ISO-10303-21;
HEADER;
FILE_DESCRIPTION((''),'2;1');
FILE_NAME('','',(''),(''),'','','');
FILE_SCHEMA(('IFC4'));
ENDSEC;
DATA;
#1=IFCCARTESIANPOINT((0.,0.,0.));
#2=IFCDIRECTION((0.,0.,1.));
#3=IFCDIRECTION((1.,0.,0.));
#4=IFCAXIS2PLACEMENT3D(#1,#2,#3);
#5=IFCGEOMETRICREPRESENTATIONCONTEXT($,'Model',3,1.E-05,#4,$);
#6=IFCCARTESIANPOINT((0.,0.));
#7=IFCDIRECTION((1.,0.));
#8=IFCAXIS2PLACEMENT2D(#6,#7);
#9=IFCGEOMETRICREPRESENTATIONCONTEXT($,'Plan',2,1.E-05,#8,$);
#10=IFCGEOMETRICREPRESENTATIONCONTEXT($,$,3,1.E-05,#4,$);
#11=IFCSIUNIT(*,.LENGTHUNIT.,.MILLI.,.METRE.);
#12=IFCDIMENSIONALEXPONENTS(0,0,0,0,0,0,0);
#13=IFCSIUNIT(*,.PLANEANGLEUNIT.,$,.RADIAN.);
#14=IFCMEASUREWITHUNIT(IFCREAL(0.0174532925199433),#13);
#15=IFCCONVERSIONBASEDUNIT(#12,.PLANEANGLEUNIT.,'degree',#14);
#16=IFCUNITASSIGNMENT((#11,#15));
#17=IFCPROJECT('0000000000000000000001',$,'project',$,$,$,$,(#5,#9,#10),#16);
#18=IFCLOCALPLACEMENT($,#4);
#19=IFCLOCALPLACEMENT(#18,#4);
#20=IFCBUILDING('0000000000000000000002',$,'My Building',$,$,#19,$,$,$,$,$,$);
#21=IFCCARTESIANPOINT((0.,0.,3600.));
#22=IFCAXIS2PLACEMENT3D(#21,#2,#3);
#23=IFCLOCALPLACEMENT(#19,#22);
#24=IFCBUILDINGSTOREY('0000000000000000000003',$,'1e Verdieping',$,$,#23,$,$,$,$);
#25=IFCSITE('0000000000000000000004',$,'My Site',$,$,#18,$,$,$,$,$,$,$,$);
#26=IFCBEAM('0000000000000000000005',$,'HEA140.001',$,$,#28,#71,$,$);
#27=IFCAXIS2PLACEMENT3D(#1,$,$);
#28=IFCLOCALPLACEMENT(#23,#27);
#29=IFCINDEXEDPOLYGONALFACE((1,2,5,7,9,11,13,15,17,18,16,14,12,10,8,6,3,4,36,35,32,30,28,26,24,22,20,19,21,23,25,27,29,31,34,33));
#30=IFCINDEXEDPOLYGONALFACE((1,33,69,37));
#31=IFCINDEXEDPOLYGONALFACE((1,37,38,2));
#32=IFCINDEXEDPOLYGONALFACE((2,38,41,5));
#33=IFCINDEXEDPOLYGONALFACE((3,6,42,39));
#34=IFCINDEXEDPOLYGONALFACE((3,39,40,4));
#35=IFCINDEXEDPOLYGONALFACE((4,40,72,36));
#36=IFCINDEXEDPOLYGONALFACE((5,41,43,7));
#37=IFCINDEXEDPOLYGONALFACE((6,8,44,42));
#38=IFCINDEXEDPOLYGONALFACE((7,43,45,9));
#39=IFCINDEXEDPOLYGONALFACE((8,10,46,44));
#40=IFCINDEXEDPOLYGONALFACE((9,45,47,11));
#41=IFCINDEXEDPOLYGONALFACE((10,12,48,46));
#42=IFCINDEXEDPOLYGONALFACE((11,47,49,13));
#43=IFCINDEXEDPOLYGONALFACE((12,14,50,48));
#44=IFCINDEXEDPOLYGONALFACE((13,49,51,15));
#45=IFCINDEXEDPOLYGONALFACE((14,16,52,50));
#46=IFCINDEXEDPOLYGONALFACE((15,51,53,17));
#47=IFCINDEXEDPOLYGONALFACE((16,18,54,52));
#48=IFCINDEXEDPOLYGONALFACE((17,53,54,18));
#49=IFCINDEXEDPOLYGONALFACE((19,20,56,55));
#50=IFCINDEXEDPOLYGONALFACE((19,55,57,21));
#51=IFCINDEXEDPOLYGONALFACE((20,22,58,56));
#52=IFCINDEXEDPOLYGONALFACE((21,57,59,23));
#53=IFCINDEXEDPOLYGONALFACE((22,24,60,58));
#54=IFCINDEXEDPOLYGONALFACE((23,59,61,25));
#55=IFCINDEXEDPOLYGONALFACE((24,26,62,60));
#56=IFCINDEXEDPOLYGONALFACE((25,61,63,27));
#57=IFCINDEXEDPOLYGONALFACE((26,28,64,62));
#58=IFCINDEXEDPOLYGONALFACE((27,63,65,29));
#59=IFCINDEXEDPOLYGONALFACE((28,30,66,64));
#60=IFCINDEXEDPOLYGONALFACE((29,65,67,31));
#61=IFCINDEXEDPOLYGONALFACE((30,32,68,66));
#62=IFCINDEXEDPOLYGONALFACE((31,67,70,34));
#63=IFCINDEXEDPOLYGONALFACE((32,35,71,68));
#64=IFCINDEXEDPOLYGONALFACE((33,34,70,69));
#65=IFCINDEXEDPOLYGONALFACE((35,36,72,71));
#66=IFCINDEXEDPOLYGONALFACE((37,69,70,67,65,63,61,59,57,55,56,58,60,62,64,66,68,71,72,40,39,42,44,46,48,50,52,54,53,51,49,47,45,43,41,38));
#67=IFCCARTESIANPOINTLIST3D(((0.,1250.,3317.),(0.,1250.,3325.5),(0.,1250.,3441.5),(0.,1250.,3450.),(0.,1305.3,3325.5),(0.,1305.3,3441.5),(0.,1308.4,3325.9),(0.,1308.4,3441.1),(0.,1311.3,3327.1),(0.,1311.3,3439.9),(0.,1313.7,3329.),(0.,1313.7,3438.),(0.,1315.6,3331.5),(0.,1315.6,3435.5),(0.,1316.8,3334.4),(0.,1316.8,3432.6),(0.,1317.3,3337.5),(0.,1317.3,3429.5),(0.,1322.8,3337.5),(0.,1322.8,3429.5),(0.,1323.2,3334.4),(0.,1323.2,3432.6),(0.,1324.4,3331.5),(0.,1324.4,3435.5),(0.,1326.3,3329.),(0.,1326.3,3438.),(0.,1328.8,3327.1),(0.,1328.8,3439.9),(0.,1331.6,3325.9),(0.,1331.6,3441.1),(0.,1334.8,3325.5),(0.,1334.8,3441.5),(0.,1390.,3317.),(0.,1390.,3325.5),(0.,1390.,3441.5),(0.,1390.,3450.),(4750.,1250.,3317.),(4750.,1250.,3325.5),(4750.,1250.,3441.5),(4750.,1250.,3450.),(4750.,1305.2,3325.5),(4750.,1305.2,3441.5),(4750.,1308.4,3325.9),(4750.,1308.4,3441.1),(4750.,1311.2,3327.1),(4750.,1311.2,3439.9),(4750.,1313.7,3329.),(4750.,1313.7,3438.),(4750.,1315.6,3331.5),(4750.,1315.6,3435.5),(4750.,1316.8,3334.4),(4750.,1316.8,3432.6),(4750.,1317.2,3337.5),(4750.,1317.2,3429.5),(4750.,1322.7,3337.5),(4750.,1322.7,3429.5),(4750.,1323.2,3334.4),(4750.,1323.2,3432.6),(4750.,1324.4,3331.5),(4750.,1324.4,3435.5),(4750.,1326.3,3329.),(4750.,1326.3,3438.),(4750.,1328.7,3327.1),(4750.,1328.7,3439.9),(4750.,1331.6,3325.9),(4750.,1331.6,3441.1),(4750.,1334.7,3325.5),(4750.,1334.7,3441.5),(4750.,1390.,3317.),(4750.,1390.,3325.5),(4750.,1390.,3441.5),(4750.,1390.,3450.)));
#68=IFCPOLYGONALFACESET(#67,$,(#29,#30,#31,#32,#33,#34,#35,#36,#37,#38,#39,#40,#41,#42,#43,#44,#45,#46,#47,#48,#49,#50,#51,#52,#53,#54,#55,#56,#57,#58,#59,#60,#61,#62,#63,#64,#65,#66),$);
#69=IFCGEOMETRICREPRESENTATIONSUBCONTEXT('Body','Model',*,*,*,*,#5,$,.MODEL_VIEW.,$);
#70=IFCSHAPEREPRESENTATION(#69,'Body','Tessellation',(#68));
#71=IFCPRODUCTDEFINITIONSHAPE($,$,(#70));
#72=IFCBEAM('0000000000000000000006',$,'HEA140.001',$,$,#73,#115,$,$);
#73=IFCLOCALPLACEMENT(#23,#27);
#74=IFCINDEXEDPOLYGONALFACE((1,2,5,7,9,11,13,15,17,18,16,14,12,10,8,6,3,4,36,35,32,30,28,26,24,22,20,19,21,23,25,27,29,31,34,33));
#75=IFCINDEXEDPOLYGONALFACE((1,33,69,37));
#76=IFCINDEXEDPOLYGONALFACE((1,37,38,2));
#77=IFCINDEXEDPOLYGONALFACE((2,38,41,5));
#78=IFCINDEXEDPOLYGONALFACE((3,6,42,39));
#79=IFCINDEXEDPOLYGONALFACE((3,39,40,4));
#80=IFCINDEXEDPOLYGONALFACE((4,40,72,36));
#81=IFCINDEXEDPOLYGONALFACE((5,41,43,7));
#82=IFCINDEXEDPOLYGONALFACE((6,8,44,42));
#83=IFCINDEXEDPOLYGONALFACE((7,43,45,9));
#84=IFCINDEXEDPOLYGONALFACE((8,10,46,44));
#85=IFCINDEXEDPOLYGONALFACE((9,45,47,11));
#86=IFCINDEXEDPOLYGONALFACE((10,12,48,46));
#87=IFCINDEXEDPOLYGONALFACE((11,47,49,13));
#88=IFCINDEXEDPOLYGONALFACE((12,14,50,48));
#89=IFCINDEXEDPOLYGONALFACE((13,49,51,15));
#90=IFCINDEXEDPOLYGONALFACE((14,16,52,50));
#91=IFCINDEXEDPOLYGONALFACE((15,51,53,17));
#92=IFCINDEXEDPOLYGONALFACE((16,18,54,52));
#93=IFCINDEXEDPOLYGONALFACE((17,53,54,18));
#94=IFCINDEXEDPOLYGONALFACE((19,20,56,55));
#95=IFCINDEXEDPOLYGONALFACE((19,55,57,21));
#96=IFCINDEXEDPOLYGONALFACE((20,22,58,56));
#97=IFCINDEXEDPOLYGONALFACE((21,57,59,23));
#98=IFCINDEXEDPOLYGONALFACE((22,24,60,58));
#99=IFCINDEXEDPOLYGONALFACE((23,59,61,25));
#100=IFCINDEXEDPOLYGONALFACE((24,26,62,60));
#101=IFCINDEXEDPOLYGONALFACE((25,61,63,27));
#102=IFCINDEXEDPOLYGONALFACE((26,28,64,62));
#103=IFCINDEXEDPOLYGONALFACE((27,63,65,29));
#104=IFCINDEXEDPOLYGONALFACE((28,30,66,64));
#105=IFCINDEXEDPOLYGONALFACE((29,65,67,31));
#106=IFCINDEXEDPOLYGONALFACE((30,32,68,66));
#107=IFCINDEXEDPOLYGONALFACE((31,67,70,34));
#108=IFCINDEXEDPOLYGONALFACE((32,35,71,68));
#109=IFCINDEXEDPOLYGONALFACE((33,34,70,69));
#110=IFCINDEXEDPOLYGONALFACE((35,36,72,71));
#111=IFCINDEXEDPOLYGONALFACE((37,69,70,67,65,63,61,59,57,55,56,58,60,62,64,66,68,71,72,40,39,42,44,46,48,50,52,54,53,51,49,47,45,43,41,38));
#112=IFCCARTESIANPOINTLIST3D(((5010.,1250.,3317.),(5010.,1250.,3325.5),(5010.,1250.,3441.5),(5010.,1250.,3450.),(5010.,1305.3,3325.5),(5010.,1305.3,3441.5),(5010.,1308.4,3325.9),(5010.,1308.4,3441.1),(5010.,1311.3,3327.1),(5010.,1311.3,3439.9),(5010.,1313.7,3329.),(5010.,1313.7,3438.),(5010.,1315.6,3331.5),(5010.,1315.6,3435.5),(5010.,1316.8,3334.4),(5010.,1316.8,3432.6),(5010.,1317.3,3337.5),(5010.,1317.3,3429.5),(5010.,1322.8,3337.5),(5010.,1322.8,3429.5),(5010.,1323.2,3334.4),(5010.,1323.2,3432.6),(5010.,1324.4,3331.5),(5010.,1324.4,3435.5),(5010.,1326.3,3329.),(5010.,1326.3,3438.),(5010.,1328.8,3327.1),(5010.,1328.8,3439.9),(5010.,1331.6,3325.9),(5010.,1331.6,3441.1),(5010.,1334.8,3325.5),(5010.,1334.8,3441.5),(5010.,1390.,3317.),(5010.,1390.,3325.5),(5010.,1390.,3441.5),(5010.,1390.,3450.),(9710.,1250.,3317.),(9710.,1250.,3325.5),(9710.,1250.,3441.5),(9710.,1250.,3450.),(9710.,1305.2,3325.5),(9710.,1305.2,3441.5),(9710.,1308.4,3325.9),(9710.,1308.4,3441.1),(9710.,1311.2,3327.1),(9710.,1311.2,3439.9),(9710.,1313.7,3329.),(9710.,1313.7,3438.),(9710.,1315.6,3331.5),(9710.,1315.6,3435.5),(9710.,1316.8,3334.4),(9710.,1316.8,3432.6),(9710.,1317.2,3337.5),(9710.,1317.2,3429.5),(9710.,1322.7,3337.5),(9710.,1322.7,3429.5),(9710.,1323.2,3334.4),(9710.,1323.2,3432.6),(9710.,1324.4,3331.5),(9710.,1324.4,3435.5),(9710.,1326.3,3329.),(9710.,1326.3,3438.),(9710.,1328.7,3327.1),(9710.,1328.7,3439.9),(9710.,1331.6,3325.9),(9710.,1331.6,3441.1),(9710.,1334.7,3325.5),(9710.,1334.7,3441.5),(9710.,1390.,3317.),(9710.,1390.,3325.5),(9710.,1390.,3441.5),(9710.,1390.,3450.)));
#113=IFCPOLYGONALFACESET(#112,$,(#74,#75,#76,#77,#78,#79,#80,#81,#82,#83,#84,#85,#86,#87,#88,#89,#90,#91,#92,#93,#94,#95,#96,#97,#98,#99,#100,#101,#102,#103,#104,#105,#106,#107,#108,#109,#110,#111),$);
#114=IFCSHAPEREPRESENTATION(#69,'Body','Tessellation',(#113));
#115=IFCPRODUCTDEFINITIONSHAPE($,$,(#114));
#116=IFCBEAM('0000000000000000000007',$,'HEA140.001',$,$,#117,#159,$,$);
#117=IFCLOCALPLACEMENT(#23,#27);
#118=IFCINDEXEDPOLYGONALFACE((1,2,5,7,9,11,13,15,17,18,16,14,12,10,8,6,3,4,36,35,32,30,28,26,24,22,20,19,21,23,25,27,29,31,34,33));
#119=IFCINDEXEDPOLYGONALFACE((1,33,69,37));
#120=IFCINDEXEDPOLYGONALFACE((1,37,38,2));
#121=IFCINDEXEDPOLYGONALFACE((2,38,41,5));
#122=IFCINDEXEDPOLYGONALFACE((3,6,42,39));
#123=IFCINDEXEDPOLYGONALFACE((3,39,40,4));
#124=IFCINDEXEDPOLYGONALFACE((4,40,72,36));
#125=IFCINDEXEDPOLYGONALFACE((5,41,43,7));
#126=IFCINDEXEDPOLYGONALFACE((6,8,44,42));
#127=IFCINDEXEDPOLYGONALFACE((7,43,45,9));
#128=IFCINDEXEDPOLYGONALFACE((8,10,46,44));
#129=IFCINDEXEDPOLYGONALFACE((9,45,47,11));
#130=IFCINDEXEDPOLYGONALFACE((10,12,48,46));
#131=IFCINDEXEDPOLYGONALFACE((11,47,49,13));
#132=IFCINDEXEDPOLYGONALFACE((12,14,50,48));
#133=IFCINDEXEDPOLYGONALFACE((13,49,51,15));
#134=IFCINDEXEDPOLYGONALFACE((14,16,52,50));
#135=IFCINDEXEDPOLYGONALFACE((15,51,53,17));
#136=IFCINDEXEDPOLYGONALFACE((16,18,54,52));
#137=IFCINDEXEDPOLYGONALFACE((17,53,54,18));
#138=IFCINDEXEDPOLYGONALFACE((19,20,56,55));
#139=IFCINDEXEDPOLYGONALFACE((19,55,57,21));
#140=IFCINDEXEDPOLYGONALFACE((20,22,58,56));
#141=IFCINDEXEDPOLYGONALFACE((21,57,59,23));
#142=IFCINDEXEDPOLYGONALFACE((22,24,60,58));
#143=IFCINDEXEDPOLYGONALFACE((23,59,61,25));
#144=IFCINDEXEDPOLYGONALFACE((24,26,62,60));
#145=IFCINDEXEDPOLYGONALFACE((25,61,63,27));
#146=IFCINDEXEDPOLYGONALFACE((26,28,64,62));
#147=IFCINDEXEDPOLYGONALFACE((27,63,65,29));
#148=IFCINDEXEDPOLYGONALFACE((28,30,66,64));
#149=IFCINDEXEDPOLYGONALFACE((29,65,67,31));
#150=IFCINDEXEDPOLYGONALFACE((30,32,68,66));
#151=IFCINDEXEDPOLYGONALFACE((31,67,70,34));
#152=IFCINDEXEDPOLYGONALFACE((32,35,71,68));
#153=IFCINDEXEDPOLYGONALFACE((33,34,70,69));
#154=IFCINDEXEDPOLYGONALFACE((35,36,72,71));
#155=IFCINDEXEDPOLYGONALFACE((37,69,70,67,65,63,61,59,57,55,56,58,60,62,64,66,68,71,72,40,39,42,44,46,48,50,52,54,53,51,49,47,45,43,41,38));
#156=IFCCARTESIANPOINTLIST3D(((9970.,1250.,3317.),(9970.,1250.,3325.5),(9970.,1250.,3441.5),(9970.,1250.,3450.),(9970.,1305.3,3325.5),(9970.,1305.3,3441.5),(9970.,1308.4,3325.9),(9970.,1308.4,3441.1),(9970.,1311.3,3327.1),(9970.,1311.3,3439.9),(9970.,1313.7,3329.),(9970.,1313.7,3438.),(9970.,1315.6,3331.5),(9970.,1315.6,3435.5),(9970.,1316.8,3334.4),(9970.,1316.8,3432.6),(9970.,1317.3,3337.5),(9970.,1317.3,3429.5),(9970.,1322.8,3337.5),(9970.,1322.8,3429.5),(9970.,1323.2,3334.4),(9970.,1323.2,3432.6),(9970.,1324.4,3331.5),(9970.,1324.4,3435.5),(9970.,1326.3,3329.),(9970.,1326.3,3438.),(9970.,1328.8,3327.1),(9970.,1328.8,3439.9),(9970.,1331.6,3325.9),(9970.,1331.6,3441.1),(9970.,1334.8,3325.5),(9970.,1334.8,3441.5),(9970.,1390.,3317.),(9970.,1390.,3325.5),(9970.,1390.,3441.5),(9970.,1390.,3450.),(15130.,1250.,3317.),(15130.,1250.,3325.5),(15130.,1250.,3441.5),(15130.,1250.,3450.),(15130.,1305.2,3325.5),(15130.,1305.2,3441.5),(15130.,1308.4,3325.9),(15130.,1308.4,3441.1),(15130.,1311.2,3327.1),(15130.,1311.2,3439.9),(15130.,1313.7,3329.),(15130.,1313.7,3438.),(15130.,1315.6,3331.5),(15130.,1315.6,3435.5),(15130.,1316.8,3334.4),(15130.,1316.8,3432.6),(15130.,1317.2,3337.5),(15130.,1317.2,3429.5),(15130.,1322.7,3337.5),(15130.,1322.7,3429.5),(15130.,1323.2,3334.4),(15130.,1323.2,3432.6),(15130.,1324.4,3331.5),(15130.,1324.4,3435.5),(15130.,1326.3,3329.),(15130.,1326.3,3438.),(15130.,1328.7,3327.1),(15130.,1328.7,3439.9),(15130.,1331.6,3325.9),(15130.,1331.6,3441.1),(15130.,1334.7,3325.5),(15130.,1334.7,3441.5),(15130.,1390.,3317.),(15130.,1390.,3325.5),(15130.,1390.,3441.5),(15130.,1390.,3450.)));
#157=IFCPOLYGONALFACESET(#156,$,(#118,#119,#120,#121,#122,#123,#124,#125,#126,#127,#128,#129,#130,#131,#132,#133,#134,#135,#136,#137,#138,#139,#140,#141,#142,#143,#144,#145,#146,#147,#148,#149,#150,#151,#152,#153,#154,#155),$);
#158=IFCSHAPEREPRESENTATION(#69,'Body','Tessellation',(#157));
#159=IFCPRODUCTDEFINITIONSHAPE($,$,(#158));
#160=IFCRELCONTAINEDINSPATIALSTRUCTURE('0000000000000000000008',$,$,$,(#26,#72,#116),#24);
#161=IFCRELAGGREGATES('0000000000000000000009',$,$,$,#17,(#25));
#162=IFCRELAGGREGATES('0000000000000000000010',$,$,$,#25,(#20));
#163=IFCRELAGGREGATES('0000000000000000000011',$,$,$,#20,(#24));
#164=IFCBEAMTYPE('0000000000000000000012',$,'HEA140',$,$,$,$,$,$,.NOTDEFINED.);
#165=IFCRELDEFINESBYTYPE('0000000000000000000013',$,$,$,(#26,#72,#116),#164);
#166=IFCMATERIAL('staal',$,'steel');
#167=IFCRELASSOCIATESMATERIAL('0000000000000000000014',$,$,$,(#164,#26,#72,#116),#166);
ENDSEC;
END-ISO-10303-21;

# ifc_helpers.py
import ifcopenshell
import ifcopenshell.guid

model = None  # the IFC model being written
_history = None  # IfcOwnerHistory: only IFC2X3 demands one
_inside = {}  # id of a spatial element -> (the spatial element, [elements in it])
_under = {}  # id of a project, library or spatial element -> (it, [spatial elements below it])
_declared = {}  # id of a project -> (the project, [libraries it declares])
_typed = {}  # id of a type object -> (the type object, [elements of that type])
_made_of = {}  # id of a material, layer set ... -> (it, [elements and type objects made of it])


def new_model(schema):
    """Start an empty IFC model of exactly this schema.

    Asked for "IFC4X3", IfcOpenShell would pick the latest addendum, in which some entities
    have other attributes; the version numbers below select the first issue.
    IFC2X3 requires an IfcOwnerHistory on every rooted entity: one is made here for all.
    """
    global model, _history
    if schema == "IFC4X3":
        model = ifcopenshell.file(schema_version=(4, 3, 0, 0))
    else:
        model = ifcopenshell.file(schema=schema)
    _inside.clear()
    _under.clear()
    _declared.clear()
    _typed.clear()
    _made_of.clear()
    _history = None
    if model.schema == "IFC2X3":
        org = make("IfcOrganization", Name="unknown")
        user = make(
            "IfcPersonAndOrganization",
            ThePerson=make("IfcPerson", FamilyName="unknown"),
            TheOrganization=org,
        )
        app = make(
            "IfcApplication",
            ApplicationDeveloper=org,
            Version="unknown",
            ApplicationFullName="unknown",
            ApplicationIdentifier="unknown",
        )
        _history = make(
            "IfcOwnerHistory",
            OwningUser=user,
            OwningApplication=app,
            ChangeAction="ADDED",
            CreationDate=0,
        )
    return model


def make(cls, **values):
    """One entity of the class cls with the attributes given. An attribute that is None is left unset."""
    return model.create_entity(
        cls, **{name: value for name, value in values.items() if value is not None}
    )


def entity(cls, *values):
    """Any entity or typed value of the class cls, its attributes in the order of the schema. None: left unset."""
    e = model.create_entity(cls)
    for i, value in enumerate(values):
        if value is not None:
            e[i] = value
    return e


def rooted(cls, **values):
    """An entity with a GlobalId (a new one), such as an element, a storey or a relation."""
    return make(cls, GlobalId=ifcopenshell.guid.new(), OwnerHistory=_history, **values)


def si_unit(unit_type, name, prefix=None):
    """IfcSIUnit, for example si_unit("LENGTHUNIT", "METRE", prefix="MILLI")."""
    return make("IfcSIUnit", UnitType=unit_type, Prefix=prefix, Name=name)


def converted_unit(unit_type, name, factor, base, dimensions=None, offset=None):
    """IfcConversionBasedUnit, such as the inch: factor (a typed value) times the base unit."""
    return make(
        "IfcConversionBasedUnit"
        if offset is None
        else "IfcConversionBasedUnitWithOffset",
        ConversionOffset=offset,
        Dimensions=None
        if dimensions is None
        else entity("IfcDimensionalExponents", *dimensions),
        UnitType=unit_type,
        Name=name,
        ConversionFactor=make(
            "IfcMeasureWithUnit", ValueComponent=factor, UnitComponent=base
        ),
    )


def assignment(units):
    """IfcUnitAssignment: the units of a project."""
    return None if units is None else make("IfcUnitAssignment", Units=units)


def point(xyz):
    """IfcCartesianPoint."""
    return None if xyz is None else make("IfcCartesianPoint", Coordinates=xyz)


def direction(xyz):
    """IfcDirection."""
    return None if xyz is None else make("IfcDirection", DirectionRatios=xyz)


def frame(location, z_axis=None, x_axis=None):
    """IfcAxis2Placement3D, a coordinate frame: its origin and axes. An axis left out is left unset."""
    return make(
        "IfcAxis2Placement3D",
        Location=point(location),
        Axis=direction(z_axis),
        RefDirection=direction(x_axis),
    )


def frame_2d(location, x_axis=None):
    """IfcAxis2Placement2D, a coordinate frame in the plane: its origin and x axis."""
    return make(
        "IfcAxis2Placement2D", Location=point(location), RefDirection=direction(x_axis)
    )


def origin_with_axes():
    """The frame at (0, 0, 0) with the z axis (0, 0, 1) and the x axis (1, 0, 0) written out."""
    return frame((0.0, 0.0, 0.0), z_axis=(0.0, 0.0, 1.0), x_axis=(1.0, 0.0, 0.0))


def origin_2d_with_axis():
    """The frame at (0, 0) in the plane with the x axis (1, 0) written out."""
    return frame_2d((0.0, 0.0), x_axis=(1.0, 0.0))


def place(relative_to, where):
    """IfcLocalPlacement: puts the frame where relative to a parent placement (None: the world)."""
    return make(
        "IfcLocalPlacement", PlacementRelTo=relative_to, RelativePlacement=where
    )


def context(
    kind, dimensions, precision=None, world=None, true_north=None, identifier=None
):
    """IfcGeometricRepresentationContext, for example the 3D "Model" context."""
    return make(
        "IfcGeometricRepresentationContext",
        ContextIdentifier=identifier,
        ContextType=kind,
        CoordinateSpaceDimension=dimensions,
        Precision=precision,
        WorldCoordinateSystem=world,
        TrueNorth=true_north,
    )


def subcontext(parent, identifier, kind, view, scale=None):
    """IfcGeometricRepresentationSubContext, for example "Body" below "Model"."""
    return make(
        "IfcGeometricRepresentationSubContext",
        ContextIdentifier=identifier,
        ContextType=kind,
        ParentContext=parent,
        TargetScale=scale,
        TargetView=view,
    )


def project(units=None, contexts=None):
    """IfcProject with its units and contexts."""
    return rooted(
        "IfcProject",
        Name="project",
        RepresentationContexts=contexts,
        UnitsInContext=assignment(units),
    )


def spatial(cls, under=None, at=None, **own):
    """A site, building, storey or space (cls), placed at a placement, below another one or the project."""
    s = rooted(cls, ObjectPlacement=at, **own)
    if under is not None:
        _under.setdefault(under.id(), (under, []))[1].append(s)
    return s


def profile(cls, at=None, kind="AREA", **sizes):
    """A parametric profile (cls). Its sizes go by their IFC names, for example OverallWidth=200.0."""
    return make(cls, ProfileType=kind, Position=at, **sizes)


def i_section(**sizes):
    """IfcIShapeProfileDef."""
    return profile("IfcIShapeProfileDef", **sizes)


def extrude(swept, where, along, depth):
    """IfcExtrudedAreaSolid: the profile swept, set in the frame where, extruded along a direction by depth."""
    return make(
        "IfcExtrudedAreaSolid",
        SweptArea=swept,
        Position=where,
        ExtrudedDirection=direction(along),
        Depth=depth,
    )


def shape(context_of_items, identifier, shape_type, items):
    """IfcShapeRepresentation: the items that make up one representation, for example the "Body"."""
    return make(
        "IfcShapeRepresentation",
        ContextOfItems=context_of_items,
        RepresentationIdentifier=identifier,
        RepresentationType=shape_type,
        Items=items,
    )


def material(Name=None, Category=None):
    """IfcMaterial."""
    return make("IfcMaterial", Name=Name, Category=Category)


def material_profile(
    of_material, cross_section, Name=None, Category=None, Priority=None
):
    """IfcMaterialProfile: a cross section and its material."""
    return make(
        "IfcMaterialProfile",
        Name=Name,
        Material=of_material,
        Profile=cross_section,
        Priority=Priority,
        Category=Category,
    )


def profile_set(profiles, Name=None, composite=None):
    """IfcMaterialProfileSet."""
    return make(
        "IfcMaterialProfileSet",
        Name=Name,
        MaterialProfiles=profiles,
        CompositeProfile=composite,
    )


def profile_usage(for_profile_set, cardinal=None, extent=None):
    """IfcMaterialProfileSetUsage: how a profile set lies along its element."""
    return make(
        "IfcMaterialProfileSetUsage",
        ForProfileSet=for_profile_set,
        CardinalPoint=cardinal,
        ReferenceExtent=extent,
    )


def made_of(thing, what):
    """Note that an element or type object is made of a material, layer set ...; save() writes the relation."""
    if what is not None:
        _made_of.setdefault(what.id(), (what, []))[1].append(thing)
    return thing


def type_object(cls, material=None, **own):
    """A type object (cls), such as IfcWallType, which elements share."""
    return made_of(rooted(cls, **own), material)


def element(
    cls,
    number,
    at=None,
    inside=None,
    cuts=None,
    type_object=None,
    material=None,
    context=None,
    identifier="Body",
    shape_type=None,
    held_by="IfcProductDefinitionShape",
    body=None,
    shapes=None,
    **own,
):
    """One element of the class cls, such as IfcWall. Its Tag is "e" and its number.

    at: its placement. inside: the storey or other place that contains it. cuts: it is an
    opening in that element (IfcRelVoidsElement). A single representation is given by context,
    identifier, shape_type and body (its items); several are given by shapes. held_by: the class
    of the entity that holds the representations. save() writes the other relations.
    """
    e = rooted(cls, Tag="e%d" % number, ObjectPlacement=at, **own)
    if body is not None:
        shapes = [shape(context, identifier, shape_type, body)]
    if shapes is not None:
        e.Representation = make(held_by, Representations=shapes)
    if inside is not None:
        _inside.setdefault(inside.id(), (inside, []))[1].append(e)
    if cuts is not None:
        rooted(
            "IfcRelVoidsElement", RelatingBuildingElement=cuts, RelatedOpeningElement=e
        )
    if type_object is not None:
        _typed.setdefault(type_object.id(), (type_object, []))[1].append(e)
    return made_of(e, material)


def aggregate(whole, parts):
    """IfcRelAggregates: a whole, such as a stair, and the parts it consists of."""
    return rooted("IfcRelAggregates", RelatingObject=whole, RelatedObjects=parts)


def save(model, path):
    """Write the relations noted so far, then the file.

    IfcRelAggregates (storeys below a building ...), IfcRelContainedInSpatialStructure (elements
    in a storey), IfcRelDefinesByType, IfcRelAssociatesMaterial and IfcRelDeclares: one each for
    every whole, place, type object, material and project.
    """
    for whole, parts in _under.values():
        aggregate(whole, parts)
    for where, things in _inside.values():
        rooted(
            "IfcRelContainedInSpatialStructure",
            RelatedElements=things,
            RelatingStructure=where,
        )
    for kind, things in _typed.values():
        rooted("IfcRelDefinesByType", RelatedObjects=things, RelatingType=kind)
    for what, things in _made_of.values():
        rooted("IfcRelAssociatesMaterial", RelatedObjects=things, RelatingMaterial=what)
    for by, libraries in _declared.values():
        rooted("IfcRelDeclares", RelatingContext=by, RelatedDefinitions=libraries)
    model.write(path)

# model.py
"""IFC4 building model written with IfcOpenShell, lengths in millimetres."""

from ifc_helpers import new_model, entity, si_unit, converted_unit, frame, origin_with_axes, origin_2d_with_axis, place, context, subcontext, project, spatial, i_section, extrude, material, material_profile, profile_set, profile_usage, type_object, element, save


model = new_model("IFC4")

# Units and contexts
model_context = context("Model", 3, precision=1e-05, world=origin_with_axes())
plan_context = context("Plan", 2, precision=1e-05, world=origin_2d_with_axis())
context_of_model = context(None, 3, precision=1e-05, world=origin_with_axes())
body_context = subcontext(model_context, "Body", "Model", "MODEL_VIEW")
ifc_project = project(units=[si_unit("LENGTHUNIT", "METRE", prefix="MILLI"), converted_unit("PLANEANGLEUNIT", "degree", entity("IfcReal", 0.0174532925199433), si_unit("PLANEANGLEUNIT", "RADIAN"), dimensions=[0, 0, 0, 0, 0, 0, 0])], contexts=[model_context, plan_context, context_of_model])

# Site, building, storey
site_placement = place(None, origin_with_axes())
site = spatial("IfcSite", under=ifc_project, at=site_placement, Name="My Site")
building_placement = place(site_placement, origin_with_axes())
building = spatial("IfcBuilding", under=site, at=building_placement, Name="My Building")
storey_placement = place(building_placement, frame((0.0, 0.0, 3600.0), z_axis=(0.0, 0.0, 1.0), x_axis=(1.0, 0.0, 0.0)))
storey = spatial("IfcBuildingStorey", under=building, at=storey_placement, Name="1e Verdieping")

# Shared definitions
ifc_material_1 = material(Name="staal", Category="steel")

# Beams
ifc_material_profile_1 = material_profile(ifc_material_1, i_section(OverallWidth=140.0, OverallDepth=133.0, WebThickness=5.5, FlangeThickness=8.5, FilletRadius=12.0))
ifc_profile_set_1 = profile_set([ifc_material_profile_1], Name="HEA140")
beam_type_1 = type_object("IfcBeamType", Name="HEA140", PredefinedType="NOTDEFINED", material=ifc_profile_set_1)
ifc_profile_usage_1 = profile_usage(ifc_profile_set_1)
beam_1_placement = place(storey_placement, frame((0.0, 1320.0, 3383.5), z_axis=(1.0, 0.0, 0.0), x_axis=(0.0, 1.0, 0.0)))
element("IfcBeam", 1, at=beam_1_placement, inside=storey, type_object=beam_type_1, material=ifc_profile_usage_1, Name="HEA140.001", context=body_context, shape_type="SweptSolid", body=[
    extrude(i_section(OverallWidth=140.0, OverallDepth=133.0, WebThickness=5.5, FlangeThickness=8.5, FilletRadius=12.0), origin_with_axes(), (0.0, 0.0, 1.0), 4750.0),
])
ifc_profile_usage_2 = profile_usage(ifc_profile_set_1)
beam_2_placement = place(storey_placement, frame((5010.0, 1320.0, 3383.5), z_axis=(1.0, 0.0, 0.0), x_axis=(0.0, 1.0, 0.0)))
element("IfcBeam", 2, at=beam_2_placement, inside=storey, type_object=beam_type_1, material=ifc_profile_usage_2, Name="HEA140.001", context=body_context, shape_type="SweptSolid", body=[
    extrude(i_section(OverallWidth=140.0, OverallDepth=133.0, WebThickness=5.5, FlangeThickness=8.5, FilletRadius=12.0), origin_with_axes(), (0.0, 0.0, 1.0), 4700.0),
])
ifc_profile_usage_3 = profile_usage(ifc_profile_set_1)
beam_3_placement = place(storey_placement, frame((9970.0, 1320.0, 3383.5), z_axis=(1.0, 0.0, 0.0), x_axis=(0.0, 1.0, 0.0)))
element("IfcBeam", 3, at=beam_3_placement, inside=storey, type_object=beam_type_1, material=ifc_profile_usage_3, Name="HEA140.001", context=body_context, shape_type="SweptSolid", body=[
    extrude(i_section(OverallWidth=140.0, OverallDepth=133.0, WebThickness=5.5, FlangeThickness=8.5, FilletRadius=12.0), origin_with_axes(), (0.0, 0.0, 1.0), 5160.0),
])

save(model, "model.ifc")
